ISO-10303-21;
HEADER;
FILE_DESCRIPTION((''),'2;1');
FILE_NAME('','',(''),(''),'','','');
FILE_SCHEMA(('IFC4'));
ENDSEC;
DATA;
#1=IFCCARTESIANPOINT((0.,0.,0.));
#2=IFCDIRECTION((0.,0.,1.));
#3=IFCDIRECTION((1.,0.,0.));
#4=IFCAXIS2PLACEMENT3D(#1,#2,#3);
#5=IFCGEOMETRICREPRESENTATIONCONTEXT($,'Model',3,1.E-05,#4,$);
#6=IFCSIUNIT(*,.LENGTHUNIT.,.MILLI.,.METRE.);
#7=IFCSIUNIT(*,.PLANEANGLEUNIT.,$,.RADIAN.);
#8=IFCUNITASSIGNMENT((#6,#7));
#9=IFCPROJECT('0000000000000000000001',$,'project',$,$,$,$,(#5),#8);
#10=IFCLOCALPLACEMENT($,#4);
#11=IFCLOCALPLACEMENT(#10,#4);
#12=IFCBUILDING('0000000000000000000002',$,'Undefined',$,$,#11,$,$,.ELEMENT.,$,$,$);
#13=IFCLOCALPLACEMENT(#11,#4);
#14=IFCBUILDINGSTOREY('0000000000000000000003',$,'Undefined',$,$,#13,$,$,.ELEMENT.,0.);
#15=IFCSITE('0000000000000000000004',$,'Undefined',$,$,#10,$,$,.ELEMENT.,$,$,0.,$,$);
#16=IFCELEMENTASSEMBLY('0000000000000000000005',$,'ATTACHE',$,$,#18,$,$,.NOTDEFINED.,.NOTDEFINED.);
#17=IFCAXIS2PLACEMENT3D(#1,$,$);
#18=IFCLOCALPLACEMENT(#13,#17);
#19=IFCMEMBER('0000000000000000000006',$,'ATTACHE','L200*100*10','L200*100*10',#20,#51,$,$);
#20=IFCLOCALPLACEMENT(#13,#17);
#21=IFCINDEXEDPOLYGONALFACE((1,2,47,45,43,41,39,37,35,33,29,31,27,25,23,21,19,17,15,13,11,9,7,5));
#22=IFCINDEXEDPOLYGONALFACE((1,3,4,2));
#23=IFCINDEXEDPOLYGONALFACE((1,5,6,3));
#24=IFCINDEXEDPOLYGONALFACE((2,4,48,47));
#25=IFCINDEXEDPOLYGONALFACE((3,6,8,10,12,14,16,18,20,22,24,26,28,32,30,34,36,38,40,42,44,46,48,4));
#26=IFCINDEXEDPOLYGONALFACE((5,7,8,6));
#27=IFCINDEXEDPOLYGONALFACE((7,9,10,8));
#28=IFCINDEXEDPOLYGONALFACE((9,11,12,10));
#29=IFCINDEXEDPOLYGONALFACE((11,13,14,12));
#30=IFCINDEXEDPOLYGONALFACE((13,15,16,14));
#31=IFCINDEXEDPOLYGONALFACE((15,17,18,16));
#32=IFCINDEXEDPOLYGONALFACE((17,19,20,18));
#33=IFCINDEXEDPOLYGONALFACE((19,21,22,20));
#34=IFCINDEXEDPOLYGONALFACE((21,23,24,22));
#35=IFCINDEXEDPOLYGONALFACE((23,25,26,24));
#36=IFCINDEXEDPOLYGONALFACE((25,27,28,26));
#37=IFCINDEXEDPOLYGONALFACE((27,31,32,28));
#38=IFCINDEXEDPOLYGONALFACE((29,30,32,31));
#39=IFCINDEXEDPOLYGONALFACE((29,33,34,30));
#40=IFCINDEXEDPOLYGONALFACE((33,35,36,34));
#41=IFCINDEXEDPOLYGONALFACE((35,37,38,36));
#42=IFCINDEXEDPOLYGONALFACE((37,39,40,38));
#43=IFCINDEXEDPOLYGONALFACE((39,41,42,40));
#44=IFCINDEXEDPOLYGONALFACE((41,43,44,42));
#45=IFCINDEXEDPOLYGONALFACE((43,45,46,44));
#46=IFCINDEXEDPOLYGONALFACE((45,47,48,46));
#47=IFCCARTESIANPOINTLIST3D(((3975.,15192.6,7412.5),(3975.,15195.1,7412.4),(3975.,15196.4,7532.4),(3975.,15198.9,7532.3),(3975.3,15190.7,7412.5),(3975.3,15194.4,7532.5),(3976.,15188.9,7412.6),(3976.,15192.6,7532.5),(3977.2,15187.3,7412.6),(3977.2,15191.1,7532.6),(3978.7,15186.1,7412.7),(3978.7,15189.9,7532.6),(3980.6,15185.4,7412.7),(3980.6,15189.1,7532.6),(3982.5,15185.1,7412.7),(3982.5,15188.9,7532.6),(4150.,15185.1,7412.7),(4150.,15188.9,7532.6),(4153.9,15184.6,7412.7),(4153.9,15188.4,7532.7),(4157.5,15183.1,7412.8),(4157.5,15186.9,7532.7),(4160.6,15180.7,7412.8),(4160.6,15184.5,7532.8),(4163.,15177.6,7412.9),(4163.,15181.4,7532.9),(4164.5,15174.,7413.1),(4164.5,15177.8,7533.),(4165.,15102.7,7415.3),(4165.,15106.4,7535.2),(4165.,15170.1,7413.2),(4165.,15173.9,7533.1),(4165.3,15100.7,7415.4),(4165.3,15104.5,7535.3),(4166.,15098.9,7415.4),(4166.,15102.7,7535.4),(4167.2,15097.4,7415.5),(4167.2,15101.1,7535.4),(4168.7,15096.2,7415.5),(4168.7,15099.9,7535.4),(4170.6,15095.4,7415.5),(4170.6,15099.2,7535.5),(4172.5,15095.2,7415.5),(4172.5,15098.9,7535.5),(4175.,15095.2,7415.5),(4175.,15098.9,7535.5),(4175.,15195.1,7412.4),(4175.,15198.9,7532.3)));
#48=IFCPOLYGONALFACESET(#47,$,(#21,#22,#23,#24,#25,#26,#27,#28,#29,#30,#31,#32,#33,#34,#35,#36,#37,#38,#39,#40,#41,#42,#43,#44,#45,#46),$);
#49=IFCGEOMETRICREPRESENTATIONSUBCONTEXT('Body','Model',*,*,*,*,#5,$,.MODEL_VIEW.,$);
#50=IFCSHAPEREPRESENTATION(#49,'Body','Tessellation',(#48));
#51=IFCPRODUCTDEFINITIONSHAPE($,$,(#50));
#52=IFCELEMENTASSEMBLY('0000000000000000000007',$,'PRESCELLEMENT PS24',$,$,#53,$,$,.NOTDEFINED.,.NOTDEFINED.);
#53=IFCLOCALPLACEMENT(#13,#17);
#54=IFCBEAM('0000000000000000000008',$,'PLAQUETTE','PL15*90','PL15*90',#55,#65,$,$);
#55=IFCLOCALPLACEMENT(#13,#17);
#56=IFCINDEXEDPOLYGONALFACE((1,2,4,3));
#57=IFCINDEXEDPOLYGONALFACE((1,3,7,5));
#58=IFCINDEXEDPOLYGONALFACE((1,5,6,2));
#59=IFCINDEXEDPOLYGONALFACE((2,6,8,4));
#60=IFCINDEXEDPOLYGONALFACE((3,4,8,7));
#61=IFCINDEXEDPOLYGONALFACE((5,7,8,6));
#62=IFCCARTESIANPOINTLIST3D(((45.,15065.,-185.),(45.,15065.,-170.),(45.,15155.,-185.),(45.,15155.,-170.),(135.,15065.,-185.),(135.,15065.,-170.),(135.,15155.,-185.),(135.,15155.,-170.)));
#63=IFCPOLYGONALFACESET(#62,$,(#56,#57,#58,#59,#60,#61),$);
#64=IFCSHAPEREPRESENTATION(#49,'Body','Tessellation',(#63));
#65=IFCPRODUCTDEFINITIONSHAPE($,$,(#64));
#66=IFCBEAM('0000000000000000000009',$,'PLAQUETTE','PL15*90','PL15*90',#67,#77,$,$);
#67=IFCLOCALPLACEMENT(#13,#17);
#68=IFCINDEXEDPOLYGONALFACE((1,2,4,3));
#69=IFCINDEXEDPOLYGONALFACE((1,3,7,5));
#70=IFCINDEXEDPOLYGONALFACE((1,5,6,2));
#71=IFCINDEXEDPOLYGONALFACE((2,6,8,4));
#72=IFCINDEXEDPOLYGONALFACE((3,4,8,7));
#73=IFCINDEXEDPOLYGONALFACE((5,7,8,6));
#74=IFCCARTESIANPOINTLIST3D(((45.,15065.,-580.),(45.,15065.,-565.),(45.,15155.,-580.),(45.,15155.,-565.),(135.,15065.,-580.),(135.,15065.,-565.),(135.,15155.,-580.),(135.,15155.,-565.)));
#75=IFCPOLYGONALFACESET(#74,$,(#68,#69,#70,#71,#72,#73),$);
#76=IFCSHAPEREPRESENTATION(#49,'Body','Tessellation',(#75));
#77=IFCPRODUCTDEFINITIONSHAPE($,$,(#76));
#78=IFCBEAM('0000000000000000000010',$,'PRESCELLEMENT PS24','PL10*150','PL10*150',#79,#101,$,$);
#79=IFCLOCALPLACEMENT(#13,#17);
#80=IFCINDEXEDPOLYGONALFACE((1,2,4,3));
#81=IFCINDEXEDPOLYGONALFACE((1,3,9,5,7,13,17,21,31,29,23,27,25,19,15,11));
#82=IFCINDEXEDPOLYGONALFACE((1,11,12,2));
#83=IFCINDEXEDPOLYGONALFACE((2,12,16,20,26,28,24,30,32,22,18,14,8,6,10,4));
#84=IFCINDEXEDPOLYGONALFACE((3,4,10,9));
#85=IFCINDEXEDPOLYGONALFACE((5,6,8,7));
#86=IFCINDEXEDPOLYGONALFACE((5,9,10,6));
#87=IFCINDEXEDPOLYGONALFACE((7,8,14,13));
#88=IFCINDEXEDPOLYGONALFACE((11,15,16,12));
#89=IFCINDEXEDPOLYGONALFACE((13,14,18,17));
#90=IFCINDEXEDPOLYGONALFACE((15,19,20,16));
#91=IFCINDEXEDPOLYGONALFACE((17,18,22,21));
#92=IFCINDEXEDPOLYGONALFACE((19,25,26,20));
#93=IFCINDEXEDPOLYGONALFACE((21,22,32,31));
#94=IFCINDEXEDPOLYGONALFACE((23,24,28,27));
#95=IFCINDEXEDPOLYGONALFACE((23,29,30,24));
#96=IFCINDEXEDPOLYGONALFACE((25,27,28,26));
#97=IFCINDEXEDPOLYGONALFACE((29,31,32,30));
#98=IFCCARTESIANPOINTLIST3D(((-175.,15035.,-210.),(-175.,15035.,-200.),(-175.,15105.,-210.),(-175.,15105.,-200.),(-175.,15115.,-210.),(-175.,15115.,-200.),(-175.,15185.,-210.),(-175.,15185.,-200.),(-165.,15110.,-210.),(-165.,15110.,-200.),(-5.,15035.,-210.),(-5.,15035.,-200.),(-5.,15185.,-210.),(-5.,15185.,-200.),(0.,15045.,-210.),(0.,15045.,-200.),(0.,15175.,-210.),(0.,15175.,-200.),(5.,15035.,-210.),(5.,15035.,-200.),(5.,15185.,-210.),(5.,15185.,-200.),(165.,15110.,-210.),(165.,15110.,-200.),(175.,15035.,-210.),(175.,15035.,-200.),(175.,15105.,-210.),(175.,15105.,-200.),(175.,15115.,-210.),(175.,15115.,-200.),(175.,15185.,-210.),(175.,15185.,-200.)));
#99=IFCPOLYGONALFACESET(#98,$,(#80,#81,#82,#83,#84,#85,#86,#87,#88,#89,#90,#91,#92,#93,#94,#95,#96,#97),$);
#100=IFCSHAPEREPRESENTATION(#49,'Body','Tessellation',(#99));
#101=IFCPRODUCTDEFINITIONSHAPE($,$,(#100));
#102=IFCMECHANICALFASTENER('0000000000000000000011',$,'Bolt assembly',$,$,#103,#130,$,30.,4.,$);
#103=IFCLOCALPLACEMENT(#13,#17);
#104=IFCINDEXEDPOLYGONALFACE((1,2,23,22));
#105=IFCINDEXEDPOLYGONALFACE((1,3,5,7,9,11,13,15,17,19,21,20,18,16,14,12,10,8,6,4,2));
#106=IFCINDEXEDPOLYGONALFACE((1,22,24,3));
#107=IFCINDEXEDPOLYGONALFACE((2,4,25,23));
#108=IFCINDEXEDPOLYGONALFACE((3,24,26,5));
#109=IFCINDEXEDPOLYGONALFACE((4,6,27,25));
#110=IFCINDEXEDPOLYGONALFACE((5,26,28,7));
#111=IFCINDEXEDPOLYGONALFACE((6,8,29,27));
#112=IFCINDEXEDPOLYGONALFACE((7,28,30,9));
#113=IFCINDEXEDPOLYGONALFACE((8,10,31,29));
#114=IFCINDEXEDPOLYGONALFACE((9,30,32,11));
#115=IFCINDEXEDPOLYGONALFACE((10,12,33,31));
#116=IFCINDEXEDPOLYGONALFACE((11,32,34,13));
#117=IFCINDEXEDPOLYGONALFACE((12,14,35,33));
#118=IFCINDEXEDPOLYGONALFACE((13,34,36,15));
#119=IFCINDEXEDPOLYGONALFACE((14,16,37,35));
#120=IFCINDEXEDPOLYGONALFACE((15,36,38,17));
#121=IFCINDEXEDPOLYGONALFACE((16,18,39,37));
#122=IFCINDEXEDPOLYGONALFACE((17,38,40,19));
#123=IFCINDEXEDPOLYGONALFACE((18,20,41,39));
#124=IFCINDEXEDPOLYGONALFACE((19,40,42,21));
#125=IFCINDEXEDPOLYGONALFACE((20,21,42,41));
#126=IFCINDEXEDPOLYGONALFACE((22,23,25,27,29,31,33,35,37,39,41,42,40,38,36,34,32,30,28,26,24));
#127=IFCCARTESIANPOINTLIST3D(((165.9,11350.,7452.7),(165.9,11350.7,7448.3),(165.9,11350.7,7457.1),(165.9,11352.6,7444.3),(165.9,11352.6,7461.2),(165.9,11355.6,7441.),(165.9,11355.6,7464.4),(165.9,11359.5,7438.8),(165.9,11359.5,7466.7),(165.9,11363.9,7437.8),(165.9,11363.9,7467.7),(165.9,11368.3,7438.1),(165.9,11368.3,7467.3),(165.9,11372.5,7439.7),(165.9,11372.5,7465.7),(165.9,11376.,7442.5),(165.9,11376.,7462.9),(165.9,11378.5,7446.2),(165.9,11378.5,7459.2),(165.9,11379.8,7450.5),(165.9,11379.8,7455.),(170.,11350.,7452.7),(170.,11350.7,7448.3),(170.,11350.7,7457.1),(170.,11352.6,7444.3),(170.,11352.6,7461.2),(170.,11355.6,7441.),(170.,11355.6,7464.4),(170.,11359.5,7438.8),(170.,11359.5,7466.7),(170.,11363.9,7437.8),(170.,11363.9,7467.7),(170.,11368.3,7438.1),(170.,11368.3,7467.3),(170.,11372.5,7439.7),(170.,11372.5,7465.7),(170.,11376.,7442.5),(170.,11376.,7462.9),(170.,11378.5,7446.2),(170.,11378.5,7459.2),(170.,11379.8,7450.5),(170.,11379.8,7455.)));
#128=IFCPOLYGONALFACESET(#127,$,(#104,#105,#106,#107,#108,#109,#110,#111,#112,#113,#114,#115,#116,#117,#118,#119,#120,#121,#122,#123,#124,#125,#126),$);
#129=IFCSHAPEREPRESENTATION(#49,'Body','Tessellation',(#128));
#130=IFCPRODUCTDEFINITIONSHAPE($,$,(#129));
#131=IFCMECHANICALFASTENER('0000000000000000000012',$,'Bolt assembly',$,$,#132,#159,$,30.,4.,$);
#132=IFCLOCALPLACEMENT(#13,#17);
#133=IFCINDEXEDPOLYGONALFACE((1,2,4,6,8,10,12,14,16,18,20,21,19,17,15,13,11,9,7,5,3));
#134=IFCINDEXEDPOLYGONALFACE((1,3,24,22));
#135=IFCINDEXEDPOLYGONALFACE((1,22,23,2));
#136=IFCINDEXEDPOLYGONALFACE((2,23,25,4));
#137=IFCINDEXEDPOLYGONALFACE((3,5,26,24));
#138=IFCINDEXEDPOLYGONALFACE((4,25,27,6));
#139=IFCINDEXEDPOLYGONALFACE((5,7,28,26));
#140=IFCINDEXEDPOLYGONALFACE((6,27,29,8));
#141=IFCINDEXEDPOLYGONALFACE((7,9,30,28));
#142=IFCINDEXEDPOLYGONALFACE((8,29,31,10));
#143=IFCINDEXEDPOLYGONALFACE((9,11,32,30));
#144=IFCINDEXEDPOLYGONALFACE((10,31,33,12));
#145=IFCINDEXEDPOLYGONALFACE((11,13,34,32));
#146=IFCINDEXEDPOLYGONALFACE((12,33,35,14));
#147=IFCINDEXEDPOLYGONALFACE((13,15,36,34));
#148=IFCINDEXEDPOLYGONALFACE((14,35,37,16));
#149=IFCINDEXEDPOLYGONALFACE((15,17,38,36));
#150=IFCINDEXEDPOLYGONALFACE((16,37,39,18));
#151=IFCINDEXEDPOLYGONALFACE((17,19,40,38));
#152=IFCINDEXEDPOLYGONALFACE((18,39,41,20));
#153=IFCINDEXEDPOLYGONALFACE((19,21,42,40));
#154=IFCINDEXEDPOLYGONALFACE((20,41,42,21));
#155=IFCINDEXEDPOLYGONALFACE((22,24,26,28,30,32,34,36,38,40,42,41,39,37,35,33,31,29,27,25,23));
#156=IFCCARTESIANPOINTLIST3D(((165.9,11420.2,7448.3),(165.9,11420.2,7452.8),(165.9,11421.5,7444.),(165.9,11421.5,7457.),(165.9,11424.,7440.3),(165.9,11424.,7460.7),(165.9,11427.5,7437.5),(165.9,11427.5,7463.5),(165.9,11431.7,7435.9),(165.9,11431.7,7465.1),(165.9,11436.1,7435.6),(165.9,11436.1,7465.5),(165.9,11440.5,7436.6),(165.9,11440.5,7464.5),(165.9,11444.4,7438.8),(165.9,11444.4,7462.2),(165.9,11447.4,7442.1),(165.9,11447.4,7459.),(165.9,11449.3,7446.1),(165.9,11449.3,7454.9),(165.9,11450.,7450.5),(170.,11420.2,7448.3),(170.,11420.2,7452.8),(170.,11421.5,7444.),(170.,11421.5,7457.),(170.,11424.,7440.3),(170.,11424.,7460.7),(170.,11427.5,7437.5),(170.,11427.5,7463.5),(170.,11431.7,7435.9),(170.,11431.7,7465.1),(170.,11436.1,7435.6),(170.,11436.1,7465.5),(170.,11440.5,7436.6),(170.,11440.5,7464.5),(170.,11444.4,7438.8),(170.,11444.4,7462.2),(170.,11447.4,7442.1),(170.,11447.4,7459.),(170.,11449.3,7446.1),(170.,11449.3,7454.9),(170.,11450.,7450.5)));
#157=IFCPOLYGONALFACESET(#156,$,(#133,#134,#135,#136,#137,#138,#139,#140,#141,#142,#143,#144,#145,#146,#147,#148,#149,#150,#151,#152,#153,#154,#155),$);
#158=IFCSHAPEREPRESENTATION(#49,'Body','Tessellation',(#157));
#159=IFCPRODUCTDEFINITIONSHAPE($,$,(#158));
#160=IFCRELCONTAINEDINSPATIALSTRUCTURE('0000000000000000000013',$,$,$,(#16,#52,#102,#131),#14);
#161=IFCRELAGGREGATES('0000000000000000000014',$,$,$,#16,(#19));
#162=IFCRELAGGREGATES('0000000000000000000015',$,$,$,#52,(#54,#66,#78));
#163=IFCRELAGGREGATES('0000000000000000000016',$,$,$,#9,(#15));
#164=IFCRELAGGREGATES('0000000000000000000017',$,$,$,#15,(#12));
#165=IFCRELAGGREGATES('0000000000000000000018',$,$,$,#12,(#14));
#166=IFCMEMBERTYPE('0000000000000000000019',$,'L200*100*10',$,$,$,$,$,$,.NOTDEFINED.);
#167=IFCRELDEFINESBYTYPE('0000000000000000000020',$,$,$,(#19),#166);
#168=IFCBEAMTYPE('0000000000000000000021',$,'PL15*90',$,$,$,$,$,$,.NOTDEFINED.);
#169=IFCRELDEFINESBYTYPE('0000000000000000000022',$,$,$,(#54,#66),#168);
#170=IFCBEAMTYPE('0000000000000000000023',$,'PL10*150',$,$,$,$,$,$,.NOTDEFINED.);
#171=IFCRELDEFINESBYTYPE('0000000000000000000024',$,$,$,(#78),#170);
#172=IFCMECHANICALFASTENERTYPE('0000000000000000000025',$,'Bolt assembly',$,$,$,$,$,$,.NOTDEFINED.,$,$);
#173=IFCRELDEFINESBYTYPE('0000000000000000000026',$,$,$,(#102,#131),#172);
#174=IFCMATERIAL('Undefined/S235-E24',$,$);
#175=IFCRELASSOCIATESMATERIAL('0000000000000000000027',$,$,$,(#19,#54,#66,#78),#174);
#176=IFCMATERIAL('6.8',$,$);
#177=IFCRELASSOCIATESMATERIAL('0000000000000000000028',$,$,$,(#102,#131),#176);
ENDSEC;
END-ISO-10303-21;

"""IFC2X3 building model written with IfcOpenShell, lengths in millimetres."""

from ifc_helpers import new_model, si_unit, frame, origin_with_axes, origin_2d_with_axis, place, context, subcontext, project, spatial, polyline, rectangle, circle, l_section, outline, extrude, boolean, source, transform, mapped, material, type_object, element, aggregate, save


model = new_model("IFC2X3")

# Units and contexts
model_context = context("Model", 3, precision=1e-05, world=origin_with_axes())
body_context = subcontext(model_context, "Body", "Model", "MODEL_VIEW")
ifc_project = project(units=[si_unit("LENGTHUNIT", "METRE", prefix="MILLI"), si_unit("PLANEANGLEUNIT", "RADIAN")], contexts=[model_context])

# Site, building, storey
site_placement = place(None, origin_with_axes())
site = spatial("IfcSite", under=ifc_project, at=site_placement, Name="Undefined", CompositionType="ELEMENT", RefElevation=0.0)
building_placement = place(site_placement, origin_with_axes())
building = spatial("IfcBuilding", under=site, at=building_placement, Name="Undefined", CompositionType="ELEMENT")
storey_placement = place(building_placement, origin_with_axes())
storey = spatial("IfcBuildingStorey", under=building, at=storey_placement, Name="Undefined", CompositionType="ELEMENT", Elevation=0.0)

# Shared definitions
ifc_material_1 = material(Name="Undefined/S235-E24")

# Element assembly, member
member_type = type_object("IfcMemberType", Name="L200*100*10", PredefinedType="NOTDEFINED")
assembly_1_placement = place(storey_placement, origin_with_axes())
assembly_1 = element("IfcElementAssembly", 1, at=assembly_1_placement, inside=storey, Name="ATTACHE", AssemblyPlace="NOTDEFINED", PredefinedType="NOTDEFINED")
member_1_placement = place(assembly_1_placement, frame((4075.0, 15145.1, 7414.0), z_axis=(-1.0, 0.0, 0.0), x_axis=(0.0, 0.031411, 0.999507)))
member_1 = element("IfcMember", 2, at=member_1_placement, type_object=member_type, material=ifc_material_1, Name="ATTACHE", Description="L200*100*10", ObjectType="L200*100*10", context=body_context, shape_type="SweptSolid", body=[
    extrude(l_section(Depth=200.0, Width=100.0, Thickness=10.0, FilletRadius=15.0, EdgeRadius=7.5, at=origin_2d_with_axis()), frame((120.0, 0.0, 0.0), z_axis=(-1.0, 0.0, 0.0), x_axis=(0.0, -1.0, 0.0)), (0.0, 0.0, 1.0), 120.0),
])
aggregate(assembly_1, [member_1])

# Element assembly, beams
assembly_2_placement = place(storey_placement, origin_with_axes())
assembly_2 = element("IfcElementAssembly", 3, at=assembly_2_placement, inside=storey, Name="PRESCELLEMENT PS24", AssemblyPlace="NOTDEFINED", PredefinedType="NOTDEFINED")
beam_type_1 = type_object("IfcBeamType", Name="PL15*90", PredefinedType="NOTDEFINED")
beam_1_placement = place(assembly_2_placement, frame((135.0, 15065.0, -177.5), z_axis=(0.0, 0.0, 1.0), x_axis=(0.0, 1.0, 0.0)))
beam_1 = element("IfcBeam", 4, at=beam_1_placement, type_object=beam_type_1, material=ifc_material_1, Name="PLAQUETTE", Description="PL15*90", ObjectType="PL15*90", context=body_context, shape_type="SweptSolid", body=[
    extrude(outline(polyline([(0.0, 0.0), (90.0, 0.0), (90.0, 90.0), (0.0, 90.0), (0.0, 0.0)])), frame((0.0, 0.0, -7.5), z_axis=(0.0, 0.0, 1.0), x_axis=(1.0, 0.0, 0.0)), (0.0, 0.0, 1.0), 15.0),
])
beam_2_placement = place(assembly_2_placement, frame((135.0, 15065.0, -572.5), z_axis=(0.0, 0.0, 1.0), x_axis=(0.0, 1.0, 0.0)))
beam_2 = element("IfcBeam", 5, at=beam_2_placement, type_object=beam_type_1, material=ifc_material_1, Name="PLAQUETTE", Description="PL15*90", ObjectType="PL15*90", context=body_context, shape_type="SweptSolid", body=[
    extrude(outline(polyline([(0.0, 0.0), (90.0, 0.0), (90.0, 90.0), (0.0, 90.0), (0.0, 0.0)])), frame((0.0, 0.0, -7.5), z_axis=(0.0, 0.0, 1.0), x_axis=(1.0, 0.0, 0.0)), (0.0, 0.0, 1.0), 15.0),
])
beam_type_2 = type_object("IfcBeamType", Name="PL10*150", PredefinedType="NOTDEFINED")
beam_3_placement = place(assembly_2_placement, frame((175.0, 15110.0, -205.0), z_axis=(0.0, -1.0, 0.0), x_axis=(-1.0, 0.0, 0.0)))
beam_3 = element("IfcBeam", 6, at=beam_3_placement, type_object=beam_type_2, material=ifc_material_1, Name="PRESCELLEMENT PS24", Description="PL10*150", ObjectType="PL10*150", context=body_context, shape_type="CSG", body=[
    boolean("DIFFERENCE", boolean("DIFFERENCE", boolean("DIFFERENCE", boolean("DIFFERENCE", extrude(rectangle(XDim=10.0, YDim=150.0, at=origin_2d_with_axis()), frame((350.0, 0.0, 0.0), z_axis=(-1.0, 0.0, 0.0), x_axis=(0.0, -1.0, 0.0)), (0.0, 0.0, 1.0), 350.0), extrude(outline(polyline([(0.0, 0.0), (11.2, 0.0), (4.5, 8.9), (0.0, 0.0)])), frame((0.0, 7.5, -5.0), z_axis=(0.0, -1.0, 0.0), x_axis=(0.894427, 0.0, 0.447214)), (0.0, 0.0, 1.0), 15.0)), extrude(outline(polyline([(0.0, 0.0), (11.2, 0.0), (4.5, 8.9), (0.0, 0.0)])), frame((180.0, 7.5, -75.0), z_axis=(0.0, -1.0, 0.0), x_axis=(-0.447214, 0.0, 0.894427)), (0.0, 0.0, 1.0), 15.0)), extrude(outline(polyline([(0.0, 0.0), (11.2, 0.0), (6.7, 8.9), (0.0, 0.0)])), frame((340.0, 7.5, 0.0), z_axis=(0.0, -1.0, 0.0), x_axis=(0.894427, 0.0, -0.447214)), (0.0, 0.0, 1.0), 15.0)), extrude(outline(polyline([(0.0, 0.0), (11.2, 0.0), (4.5, 8.9), (0.0, 0.0)])), frame((170.0, 7.5, 75.0), z_axis=(0.0, -1.0, 0.0), x_axis=(0.447214, 0.0, -0.894427)), (0.0, 0.0, 1.0), 15.0)),
])
aggregate(assembly_2, [beam_1, beam_2, beam_3])

# Mechanical fasteners
ifc_material_2 = material(Name="6.8")
mechanical_fastener_type = type_object("IfcMechanicalFastenerType", Name="Bolt assembly")
shared_shape_1 = source(origin_with_axes(), body_context, "Body", "SweptSolid", [
    extrude(circle(Radius=15.0, at=origin_2d_with_axis()), frame((0.0, 0.0, 0.0), z_axis=(0.0, 1.0, 0.0), x_axis=(1.0, 0.0, 0.0)), (0.0, 0.0, 1.0), 4.1),
])
for number, where, z_axis, x_axis, name in (
    (7, (170.0, 11365.0, 7452.7), (0.0, 0.0, -1.0), (0.0, -1.0, 0.0), "Bolt assembly"),
    (8, (170.0, 11435.0, 7450.5), (0.0, 0.0, 1.0), (0.0, 1.0, 0.0), "Bolt assembly"),
):
    element("IfcMechanicalFastener", number, at=place(storey_placement, frame(where, z_axis=z_axis, x_axis=x_axis)), inside=storey, type_object=mechanical_fastener_type, material=ifc_material_2, Name=name, NominalDiameter=30.0, NominalLength=4.0, context=body_context, shape_type="MappedRepresentation", body=[
        mapped(shared_shape_1, transform((0.0, 0.0, 0.0))),
    ])

save(model, "model.ifc")
